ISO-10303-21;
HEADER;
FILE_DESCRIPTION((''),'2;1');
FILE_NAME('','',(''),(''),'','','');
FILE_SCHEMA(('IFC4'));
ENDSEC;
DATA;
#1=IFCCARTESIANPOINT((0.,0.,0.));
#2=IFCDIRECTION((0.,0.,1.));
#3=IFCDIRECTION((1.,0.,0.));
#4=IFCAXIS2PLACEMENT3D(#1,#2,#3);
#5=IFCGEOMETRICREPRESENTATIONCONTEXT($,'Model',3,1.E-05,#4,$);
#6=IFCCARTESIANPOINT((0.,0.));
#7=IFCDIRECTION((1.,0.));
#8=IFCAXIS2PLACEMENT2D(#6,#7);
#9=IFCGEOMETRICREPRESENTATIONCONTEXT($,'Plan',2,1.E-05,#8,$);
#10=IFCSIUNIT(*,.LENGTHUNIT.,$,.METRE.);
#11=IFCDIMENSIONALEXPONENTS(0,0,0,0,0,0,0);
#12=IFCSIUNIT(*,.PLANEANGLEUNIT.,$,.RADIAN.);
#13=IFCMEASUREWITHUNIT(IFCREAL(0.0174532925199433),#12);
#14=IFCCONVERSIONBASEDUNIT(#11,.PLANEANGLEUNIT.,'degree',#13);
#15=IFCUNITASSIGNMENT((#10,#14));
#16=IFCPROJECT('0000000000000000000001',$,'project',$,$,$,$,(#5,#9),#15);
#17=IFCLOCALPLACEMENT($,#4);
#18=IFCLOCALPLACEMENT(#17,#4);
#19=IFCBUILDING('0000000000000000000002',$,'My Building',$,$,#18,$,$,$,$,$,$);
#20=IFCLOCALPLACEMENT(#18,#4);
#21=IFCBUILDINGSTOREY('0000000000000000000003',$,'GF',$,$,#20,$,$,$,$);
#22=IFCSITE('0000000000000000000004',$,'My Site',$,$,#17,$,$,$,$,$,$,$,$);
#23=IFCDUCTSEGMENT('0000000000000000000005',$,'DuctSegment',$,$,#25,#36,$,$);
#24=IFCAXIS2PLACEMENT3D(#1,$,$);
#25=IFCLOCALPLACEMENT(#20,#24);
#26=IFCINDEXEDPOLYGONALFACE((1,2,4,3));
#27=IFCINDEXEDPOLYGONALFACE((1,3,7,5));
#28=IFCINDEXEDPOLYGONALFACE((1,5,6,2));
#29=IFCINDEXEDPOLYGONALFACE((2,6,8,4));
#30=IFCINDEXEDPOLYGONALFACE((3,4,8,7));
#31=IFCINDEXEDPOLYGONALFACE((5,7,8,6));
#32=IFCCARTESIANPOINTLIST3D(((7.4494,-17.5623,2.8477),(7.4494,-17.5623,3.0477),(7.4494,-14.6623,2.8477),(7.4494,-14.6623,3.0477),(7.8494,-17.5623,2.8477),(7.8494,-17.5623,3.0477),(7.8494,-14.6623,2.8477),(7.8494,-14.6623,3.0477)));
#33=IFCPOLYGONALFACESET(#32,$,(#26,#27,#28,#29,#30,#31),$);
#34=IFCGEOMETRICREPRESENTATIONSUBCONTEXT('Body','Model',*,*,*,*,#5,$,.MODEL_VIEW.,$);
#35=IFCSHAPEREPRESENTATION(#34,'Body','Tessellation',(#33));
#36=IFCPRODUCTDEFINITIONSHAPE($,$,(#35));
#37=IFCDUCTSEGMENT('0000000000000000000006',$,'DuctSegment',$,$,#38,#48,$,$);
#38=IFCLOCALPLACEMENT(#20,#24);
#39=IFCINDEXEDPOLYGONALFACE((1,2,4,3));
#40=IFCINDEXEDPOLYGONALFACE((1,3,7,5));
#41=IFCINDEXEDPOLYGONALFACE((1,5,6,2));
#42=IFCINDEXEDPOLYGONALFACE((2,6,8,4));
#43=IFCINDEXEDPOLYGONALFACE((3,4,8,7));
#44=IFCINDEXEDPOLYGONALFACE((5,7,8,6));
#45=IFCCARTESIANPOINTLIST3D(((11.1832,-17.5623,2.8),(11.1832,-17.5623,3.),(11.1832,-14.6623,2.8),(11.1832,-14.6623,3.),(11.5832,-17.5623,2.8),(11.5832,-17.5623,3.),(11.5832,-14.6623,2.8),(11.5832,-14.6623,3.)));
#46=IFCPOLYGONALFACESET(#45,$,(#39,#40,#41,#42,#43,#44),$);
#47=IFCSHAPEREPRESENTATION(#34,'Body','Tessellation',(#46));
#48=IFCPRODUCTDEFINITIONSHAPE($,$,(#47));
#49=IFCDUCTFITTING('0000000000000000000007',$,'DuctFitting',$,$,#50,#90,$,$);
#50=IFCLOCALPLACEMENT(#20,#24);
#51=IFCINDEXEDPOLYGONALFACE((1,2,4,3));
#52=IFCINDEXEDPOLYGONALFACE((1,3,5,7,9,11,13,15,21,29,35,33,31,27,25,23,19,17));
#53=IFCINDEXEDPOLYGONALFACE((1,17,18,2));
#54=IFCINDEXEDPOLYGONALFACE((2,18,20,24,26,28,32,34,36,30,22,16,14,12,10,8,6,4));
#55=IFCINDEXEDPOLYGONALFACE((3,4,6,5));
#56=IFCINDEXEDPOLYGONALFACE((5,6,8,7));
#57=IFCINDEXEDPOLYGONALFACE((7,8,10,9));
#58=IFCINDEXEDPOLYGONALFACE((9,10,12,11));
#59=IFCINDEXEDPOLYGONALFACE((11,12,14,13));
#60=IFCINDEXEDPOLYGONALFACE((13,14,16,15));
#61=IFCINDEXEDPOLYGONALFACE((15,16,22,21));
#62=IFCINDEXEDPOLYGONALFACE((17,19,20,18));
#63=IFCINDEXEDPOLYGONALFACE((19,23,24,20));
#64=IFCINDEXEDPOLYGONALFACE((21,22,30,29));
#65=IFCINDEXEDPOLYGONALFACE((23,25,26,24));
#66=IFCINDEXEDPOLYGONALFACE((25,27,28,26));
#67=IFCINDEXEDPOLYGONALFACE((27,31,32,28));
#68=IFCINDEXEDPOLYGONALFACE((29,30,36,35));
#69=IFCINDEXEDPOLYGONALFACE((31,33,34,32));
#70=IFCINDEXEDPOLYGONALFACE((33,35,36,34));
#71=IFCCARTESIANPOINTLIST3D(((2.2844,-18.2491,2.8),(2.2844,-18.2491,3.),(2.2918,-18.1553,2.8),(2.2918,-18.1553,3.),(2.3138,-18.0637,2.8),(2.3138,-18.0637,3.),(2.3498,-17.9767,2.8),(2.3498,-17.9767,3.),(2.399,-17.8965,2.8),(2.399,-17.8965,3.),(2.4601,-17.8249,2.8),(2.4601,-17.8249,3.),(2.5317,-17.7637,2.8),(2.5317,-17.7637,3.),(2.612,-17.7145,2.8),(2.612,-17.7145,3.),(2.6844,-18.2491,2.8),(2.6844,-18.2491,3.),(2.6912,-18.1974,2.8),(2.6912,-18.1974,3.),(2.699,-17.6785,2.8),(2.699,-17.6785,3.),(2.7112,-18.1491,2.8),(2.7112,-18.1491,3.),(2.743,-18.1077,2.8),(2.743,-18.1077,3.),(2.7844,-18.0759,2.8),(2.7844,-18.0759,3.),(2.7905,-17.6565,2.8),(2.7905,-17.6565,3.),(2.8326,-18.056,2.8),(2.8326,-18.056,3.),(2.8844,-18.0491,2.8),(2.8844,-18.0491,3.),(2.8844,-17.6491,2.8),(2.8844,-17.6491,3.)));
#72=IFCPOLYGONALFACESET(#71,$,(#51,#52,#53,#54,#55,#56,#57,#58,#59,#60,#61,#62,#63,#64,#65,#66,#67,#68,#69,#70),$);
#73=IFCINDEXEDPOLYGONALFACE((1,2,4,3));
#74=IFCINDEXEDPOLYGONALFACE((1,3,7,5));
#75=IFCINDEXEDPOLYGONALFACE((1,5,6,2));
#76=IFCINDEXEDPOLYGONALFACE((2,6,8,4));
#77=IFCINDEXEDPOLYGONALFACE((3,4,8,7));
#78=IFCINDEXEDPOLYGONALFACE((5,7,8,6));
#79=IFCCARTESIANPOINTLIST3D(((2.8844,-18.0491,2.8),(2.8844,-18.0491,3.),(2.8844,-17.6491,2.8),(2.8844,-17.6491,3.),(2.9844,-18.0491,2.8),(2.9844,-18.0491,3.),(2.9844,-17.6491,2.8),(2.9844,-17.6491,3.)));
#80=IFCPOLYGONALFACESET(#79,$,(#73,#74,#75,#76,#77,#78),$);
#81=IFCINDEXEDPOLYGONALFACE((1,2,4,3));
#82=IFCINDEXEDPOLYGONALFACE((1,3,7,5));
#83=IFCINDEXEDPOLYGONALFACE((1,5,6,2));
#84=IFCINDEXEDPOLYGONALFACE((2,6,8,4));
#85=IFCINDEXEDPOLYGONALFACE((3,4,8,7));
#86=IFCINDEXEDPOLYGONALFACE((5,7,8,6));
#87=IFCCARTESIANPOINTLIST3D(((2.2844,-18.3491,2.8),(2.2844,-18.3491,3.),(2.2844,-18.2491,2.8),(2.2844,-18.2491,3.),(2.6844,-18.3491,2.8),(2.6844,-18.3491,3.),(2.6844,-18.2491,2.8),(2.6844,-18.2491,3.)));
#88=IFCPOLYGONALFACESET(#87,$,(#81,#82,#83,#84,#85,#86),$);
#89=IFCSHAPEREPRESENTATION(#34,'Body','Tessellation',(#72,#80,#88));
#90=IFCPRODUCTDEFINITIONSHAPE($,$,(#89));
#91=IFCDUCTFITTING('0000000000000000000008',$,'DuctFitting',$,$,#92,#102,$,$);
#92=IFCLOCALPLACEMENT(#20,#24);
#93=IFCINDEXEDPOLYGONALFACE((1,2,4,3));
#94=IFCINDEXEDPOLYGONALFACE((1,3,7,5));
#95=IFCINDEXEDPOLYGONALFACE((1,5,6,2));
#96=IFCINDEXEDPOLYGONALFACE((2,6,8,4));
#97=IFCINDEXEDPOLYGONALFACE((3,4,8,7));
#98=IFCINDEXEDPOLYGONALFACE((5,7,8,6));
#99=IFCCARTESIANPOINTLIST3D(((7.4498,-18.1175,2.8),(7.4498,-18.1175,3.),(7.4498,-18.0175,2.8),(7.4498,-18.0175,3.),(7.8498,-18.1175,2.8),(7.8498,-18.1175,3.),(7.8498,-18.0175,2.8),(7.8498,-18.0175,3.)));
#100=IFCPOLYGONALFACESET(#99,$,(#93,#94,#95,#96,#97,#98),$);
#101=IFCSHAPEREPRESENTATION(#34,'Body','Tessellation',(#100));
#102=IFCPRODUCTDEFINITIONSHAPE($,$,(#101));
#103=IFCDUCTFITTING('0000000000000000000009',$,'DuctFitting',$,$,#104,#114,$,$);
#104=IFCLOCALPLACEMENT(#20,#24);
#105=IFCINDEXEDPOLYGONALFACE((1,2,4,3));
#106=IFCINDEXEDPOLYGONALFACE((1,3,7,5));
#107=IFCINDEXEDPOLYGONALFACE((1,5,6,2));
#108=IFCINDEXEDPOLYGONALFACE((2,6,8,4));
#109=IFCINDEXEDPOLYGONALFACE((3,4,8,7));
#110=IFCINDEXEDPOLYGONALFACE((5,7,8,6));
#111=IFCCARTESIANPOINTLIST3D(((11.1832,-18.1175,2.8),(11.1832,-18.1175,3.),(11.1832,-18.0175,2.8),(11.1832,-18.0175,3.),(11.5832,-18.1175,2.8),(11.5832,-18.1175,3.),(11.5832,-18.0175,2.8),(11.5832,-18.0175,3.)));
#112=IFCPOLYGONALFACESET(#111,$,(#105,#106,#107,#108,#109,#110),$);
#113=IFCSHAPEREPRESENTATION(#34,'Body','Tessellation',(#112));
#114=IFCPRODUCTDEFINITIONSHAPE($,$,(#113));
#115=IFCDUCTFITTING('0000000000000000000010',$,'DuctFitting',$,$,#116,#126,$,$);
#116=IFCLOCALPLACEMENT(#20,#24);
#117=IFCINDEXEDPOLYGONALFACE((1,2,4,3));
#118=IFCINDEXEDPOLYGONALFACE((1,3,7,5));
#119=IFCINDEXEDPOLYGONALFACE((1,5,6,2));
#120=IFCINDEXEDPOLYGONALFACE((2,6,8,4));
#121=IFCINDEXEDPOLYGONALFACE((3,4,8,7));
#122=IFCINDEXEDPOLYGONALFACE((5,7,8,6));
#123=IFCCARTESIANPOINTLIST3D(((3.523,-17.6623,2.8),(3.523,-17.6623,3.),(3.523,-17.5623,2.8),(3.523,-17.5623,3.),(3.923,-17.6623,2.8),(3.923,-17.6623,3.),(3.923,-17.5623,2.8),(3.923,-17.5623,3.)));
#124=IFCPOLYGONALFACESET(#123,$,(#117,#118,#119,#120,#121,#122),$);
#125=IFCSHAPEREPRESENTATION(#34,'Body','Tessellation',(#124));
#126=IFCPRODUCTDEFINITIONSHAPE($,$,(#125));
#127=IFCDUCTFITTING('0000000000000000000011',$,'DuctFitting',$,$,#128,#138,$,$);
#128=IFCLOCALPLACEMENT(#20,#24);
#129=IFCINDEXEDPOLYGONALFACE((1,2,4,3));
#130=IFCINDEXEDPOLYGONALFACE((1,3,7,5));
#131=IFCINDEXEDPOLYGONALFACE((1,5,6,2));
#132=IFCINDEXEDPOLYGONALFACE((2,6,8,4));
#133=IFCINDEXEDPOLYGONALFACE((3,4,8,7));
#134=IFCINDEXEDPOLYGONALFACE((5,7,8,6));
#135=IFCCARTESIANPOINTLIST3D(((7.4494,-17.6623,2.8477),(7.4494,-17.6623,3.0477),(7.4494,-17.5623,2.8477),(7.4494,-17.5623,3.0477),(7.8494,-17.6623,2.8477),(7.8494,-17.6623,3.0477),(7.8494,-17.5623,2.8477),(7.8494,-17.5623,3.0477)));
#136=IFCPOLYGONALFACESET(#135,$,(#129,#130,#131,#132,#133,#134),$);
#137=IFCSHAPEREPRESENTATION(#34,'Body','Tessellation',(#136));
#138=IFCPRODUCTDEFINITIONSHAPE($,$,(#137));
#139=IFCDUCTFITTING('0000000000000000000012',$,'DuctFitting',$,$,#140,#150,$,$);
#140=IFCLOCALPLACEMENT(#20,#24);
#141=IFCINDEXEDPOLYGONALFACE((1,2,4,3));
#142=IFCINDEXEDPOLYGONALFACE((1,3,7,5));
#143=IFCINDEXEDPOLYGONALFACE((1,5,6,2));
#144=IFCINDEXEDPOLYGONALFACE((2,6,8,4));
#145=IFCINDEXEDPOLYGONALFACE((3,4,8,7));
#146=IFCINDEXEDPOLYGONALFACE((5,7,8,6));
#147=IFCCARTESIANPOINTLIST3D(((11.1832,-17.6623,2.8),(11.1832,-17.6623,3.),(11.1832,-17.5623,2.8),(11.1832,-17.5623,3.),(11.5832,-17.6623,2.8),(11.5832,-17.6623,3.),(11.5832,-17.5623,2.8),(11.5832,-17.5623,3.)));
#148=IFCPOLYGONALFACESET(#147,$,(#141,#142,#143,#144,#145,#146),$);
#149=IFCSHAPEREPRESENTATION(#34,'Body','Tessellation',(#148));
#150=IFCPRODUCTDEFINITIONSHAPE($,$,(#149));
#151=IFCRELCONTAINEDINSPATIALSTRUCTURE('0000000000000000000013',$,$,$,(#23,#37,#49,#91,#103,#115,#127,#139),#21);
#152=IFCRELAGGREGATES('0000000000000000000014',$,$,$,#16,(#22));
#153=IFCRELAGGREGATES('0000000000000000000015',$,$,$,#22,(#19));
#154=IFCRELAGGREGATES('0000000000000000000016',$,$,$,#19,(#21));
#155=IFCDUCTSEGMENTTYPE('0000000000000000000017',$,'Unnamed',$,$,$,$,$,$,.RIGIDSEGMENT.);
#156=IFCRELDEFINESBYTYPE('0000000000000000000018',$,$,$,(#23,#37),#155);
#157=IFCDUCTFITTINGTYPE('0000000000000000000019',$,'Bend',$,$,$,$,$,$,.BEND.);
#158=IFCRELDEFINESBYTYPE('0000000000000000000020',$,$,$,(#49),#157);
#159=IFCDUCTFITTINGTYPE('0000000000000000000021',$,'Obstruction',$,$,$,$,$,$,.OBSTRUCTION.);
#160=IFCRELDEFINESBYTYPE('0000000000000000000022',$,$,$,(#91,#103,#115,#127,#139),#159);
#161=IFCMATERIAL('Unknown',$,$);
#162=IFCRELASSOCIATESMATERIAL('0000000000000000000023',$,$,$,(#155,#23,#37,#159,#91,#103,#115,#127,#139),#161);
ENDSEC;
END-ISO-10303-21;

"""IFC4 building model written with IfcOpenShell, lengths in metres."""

from ifc_helpers import new_model, entity, si_unit, converted_unit, frame, origin_with_axes, origin_2d_with_axis, place, context, subcontext, project, spatial, line, arc, indexed_curve, rectangle, outline, extrude, source, transform, mapped, material, material_profile, profile_set, profile_usage, type_object, type_shapes, element, save


model = new_model("IFC4")

# Units and contexts
model_context = context("Model", 3, precision=1e-05, world=origin_with_axes())
plan_context = context("Plan", 2, precision=1e-05, world=origin_2d_with_axis())
body_context_1 = subcontext(model_context, "Body", "Model", "MODEL_VIEW")
ifc_project = project(units=[si_unit("LENGTHUNIT", "METRE"), converted_unit("PLANEANGLEUNIT", "degree", entity("IfcReal", 0.0174532925199433), si_unit("PLANEANGLEUNIT", "RADIAN"), dimensions=[0, 0, 0, 0, 0, 0, 0])], contexts=[model_context, plan_context])

# Site, building, storey
site_placement = place(None, origin_with_axes())
site = spatial("IfcSite", under=ifc_project, at=site_placement, Name="My Site")
building_placement = place(site_placement, origin_with_axes())
building = spatial("IfcBuilding", under=site, at=building_placement, Name="My Building")
storey_placement = place(building_placement, origin_with_axes())
storey = spatial("IfcBuildingStorey", under=building, at=storey_placement, Name="GF")

# Shared definitions
ifc_material = material(Name="Unknown")

# Duct segments
ifc_material_profile_1 = material_profile(ifc_material, rectangle(XDim=0.4, YDim=0.2))
ifc_profile_set_1 = profile_set([ifc_material_profile_1])
duct_segment_type = type_object("IfcDuctSegmentType", Name="Unnamed", PredefinedType="RIGIDSEGMENT", material=ifc_profile_set_1)
ifc_profile_usage_1 = profile_usage(ifc_profile_set_1, cardinal=5)
duct_segment_1_placement = place(storey_placement, frame((7.6494, -14.6623, 2.9477), z_axis=(0.0, -1.0, 0.0), x_axis=(1.0, 0.0, 0.0)))
element("IfcDuctSegment", 1, at=duct_segment_1_placement, inside=storey, type_object=duct_segment_type, material=ifc_profile_usage_1, Name="DuctSegment", context=body_context_1, shape_type="SweptSolid", body=[
    extrude(rectangle(XDim=0.4, YDim=0.2), origin_with_axes(), (0.0, 0.0, 1.0), 2.9),
])
ifc_profile_usage_2 = profile_usage(ifc_profile_set_1, cardinal=5)
duct_segment_2_placement = place(storey_placement, frame((11.3832, -14.6623, 2.9), z_axis=(0.0, -1.0, 0.0), x_axis=(1.0, 0.0, 0.0)))
element("IfcDuctSegment", 2, at=duct_segment_2_placement, inside=storey, type_object=duct_segment_type, material=ifc_profile_usage_2, Name="DuctSegment", context=body_context_1, shape_type="SweptSolid", body=[
    extrude(rectangle(XDim=0.4, YDim=0.2), origin_with_axes(), (0.0, 0.0, 1.0), 2.9),
])

# Duct fittings
duct_fitting_type_1 = type_object("IfcDuctFittingType", Name="Bend", PredefinedType="BEND")
shared_shape_1 = source(origin_with_axes(), body_context_1, "Body", "SweptSolid", [
    extrude(outline(indexed_curve([(-0.2, 0.0), (-0.2586, -0.1414), (-0.4, -0.2), (-0.4, -0.6), (0.0243, -0.4243), (0.2, 0.0)], segments=[arc(1, 2, 3), line(3, 4), arc(4, 5, 6), line(6, 1)])), frame((0.0, -0.1, -0.1), z_axis=(0.0, -1.0, 0.0), x_axis=(1.0, 0.0, 0.0)), (0.0, 0.0, -1.0), 0.2),
    extrude(rectangle(XDim=0.4, YDim=0.2), origin_with_axes(), (0.0, 0.0, -1.0), 0.1),
    extrude(rectangle(XDim=0.4, YDim=0.2), frame((-0.4, 0.0, -0.5), z_axis=(-1.0, 0.0, 0.0), x_axis=(0.0, 0.0, -1.0)), (0.0, 0.0, 1.0), 0.1),
])
type_shapes(duct_fitting_type_1, [shared_shape_1])
duct_fitting_1_placement = place(storey_placement, frame((2.9844, -17.8491, 2.9), z_axis=(1.0, 0.0, 0.0), x_axis=(0.0, 1.0, 0.0)))
element("IfcDuctFitting", 3, at=duct_fitting_1_placement, inside=storey, type_object=duct_fitting_type_1, Name="DuctFitting", context=body_context_1, shape_type="MappedRepresentation", body=[
    mapped(shared_shape_1, transform((0.0, 0.0, 0.0), x_axis=(1.0, 0.0, 0.0), y_axis=(0.0, 1.0, 0.0), z_axis=(0.0, 0.0, 1.0), scale=1.0)),
])
ifc_material_profile_2 = material_profile(ifc_material, rectangle(XDim=0.4, YDim=0.2))
ifc_profile_set_2 = profile_set([ifc_material_profile_2])
ifc_profile_usage_3 = profile_usage(ifc_profile_set_2, cardinal=5)
duct_fitting_type_2 = type_object("IfcDuctFittingType", Name="Obstruction", PredefinedType="OBSTRUCTION", material=ifc_profile_set_2)
duct_fitting_2_placement = place(storey_placement, frame((7.6498, -18.0175, 2.9), z_axis=(0.0, -1.0, 0.0), x_axis=(1.0, 0.0, 0.0)))
element("IfcDuctFitting", 4, at=duct_fitting_2_placement, inside=storey, type_object=duct_fitting_type_2, material=ifc_profile_usage_3, Name="DuctFitting", context=body_context_1, shape_type="SweptSolid", body=[
    extrude(rectangle(XDim=0.4, YDim=0.2), origin_with_axes(), (0.0, 0.0, 1.0), 0.1),
])
ifc_profile_usage_4 = profile_usage(ifc_profile_set_2, cardinal=5)
duct_fitting_3_placement = place(storey_placement, frame((11.3832, -18.0175, 2.9), z_axis=(0.0, -1.0, 0.0), x_axis=(1.0, 0.0, 0.0)))
element("IfcDuctFitting", 5, at=duct_fitting_3_placement, inside=storey, type_object=duct_fitting_type_2, material=ifc_profile_usage_4, Name="DuctFitting", context=body_context_1, shape_type="SweptSolid", body=[
    extrude(rectangle(XDim=0.4, YDim=0.2), origin_with_axes(), (0.0, 0.0, 1.0), 0.1),
])
ifc_profile_usage_5 = profile_usage(ifc_profile_set_2, cardinal=5)
duct_fitting_4_placement = place(storey_placement, frame((3.723, -17.5623, 2.9), z_axis=(0.0, -1.0, 0.0), x_axis=(1.0, 0.0, 0.0)))
element("IfcDuctFitting", 6, at=duct_fitting_4_placement, inside=storey, type_object=duct_fitting_type_2, material=ifc_profile_usage_5, Name="DuctFitting", context=body_context_1, shape_type="SweptSolid", body=[
    extrude(rectangle(XDim=0.4, YDim=0.2), origin_with_axes(), (0.0, 0.0, 1.0), 0.1),
])
ifc_profile_usage_6 = profile_usage(ifc_profile_set_2, cardinal=5)
duct_fitting_5_placement = place(storey_placement, frame((7.6494, -17.5623, 2.9477), z_axis=(0.0, -1.0, 0.0), x_axis=(1.0, 0.0, 0.0)))
element("IfcDuctFitting", 7, at=duct_fitting_5_placement, inside=storey, type_object=duct_fitting_type_2, material=ifc_profile_usage_6, Name="DuctFitting", context=body_context_1, shape_type="SweptSolid", body=[
    extrude(rectangle(XDim=0.4, YDim=0.2), origin_with_axes(), (0.0, 0.0, 1.0), 0.1),
])
ifc_profile_usage_7 = profile_usage(ifc_profile_set_2, cardinal=5)
duct_fitting_6_placement = place(storey_placement, frame((11.3832, -17.5623, 2.9), z_axis=(0.0, -1.0, 0.0), x_axis=(1.0, 0.0, 0.0)))
element("IfcDuctFitting", 8, at=duct_fitting_6_placement, inside=storey, type_object=duct_fitting_type_2, material=ifc_profile_usage_7, Name="DuctFitting", context=body_context_1, shape_type="SweptSolid", body=[
    extrude(rectangle(XDim=0.4, YDim=0.2), origin_with_axes(), (0.0, 0.0, 1.0), 0.1),
])

save(model, "model.ifc")
